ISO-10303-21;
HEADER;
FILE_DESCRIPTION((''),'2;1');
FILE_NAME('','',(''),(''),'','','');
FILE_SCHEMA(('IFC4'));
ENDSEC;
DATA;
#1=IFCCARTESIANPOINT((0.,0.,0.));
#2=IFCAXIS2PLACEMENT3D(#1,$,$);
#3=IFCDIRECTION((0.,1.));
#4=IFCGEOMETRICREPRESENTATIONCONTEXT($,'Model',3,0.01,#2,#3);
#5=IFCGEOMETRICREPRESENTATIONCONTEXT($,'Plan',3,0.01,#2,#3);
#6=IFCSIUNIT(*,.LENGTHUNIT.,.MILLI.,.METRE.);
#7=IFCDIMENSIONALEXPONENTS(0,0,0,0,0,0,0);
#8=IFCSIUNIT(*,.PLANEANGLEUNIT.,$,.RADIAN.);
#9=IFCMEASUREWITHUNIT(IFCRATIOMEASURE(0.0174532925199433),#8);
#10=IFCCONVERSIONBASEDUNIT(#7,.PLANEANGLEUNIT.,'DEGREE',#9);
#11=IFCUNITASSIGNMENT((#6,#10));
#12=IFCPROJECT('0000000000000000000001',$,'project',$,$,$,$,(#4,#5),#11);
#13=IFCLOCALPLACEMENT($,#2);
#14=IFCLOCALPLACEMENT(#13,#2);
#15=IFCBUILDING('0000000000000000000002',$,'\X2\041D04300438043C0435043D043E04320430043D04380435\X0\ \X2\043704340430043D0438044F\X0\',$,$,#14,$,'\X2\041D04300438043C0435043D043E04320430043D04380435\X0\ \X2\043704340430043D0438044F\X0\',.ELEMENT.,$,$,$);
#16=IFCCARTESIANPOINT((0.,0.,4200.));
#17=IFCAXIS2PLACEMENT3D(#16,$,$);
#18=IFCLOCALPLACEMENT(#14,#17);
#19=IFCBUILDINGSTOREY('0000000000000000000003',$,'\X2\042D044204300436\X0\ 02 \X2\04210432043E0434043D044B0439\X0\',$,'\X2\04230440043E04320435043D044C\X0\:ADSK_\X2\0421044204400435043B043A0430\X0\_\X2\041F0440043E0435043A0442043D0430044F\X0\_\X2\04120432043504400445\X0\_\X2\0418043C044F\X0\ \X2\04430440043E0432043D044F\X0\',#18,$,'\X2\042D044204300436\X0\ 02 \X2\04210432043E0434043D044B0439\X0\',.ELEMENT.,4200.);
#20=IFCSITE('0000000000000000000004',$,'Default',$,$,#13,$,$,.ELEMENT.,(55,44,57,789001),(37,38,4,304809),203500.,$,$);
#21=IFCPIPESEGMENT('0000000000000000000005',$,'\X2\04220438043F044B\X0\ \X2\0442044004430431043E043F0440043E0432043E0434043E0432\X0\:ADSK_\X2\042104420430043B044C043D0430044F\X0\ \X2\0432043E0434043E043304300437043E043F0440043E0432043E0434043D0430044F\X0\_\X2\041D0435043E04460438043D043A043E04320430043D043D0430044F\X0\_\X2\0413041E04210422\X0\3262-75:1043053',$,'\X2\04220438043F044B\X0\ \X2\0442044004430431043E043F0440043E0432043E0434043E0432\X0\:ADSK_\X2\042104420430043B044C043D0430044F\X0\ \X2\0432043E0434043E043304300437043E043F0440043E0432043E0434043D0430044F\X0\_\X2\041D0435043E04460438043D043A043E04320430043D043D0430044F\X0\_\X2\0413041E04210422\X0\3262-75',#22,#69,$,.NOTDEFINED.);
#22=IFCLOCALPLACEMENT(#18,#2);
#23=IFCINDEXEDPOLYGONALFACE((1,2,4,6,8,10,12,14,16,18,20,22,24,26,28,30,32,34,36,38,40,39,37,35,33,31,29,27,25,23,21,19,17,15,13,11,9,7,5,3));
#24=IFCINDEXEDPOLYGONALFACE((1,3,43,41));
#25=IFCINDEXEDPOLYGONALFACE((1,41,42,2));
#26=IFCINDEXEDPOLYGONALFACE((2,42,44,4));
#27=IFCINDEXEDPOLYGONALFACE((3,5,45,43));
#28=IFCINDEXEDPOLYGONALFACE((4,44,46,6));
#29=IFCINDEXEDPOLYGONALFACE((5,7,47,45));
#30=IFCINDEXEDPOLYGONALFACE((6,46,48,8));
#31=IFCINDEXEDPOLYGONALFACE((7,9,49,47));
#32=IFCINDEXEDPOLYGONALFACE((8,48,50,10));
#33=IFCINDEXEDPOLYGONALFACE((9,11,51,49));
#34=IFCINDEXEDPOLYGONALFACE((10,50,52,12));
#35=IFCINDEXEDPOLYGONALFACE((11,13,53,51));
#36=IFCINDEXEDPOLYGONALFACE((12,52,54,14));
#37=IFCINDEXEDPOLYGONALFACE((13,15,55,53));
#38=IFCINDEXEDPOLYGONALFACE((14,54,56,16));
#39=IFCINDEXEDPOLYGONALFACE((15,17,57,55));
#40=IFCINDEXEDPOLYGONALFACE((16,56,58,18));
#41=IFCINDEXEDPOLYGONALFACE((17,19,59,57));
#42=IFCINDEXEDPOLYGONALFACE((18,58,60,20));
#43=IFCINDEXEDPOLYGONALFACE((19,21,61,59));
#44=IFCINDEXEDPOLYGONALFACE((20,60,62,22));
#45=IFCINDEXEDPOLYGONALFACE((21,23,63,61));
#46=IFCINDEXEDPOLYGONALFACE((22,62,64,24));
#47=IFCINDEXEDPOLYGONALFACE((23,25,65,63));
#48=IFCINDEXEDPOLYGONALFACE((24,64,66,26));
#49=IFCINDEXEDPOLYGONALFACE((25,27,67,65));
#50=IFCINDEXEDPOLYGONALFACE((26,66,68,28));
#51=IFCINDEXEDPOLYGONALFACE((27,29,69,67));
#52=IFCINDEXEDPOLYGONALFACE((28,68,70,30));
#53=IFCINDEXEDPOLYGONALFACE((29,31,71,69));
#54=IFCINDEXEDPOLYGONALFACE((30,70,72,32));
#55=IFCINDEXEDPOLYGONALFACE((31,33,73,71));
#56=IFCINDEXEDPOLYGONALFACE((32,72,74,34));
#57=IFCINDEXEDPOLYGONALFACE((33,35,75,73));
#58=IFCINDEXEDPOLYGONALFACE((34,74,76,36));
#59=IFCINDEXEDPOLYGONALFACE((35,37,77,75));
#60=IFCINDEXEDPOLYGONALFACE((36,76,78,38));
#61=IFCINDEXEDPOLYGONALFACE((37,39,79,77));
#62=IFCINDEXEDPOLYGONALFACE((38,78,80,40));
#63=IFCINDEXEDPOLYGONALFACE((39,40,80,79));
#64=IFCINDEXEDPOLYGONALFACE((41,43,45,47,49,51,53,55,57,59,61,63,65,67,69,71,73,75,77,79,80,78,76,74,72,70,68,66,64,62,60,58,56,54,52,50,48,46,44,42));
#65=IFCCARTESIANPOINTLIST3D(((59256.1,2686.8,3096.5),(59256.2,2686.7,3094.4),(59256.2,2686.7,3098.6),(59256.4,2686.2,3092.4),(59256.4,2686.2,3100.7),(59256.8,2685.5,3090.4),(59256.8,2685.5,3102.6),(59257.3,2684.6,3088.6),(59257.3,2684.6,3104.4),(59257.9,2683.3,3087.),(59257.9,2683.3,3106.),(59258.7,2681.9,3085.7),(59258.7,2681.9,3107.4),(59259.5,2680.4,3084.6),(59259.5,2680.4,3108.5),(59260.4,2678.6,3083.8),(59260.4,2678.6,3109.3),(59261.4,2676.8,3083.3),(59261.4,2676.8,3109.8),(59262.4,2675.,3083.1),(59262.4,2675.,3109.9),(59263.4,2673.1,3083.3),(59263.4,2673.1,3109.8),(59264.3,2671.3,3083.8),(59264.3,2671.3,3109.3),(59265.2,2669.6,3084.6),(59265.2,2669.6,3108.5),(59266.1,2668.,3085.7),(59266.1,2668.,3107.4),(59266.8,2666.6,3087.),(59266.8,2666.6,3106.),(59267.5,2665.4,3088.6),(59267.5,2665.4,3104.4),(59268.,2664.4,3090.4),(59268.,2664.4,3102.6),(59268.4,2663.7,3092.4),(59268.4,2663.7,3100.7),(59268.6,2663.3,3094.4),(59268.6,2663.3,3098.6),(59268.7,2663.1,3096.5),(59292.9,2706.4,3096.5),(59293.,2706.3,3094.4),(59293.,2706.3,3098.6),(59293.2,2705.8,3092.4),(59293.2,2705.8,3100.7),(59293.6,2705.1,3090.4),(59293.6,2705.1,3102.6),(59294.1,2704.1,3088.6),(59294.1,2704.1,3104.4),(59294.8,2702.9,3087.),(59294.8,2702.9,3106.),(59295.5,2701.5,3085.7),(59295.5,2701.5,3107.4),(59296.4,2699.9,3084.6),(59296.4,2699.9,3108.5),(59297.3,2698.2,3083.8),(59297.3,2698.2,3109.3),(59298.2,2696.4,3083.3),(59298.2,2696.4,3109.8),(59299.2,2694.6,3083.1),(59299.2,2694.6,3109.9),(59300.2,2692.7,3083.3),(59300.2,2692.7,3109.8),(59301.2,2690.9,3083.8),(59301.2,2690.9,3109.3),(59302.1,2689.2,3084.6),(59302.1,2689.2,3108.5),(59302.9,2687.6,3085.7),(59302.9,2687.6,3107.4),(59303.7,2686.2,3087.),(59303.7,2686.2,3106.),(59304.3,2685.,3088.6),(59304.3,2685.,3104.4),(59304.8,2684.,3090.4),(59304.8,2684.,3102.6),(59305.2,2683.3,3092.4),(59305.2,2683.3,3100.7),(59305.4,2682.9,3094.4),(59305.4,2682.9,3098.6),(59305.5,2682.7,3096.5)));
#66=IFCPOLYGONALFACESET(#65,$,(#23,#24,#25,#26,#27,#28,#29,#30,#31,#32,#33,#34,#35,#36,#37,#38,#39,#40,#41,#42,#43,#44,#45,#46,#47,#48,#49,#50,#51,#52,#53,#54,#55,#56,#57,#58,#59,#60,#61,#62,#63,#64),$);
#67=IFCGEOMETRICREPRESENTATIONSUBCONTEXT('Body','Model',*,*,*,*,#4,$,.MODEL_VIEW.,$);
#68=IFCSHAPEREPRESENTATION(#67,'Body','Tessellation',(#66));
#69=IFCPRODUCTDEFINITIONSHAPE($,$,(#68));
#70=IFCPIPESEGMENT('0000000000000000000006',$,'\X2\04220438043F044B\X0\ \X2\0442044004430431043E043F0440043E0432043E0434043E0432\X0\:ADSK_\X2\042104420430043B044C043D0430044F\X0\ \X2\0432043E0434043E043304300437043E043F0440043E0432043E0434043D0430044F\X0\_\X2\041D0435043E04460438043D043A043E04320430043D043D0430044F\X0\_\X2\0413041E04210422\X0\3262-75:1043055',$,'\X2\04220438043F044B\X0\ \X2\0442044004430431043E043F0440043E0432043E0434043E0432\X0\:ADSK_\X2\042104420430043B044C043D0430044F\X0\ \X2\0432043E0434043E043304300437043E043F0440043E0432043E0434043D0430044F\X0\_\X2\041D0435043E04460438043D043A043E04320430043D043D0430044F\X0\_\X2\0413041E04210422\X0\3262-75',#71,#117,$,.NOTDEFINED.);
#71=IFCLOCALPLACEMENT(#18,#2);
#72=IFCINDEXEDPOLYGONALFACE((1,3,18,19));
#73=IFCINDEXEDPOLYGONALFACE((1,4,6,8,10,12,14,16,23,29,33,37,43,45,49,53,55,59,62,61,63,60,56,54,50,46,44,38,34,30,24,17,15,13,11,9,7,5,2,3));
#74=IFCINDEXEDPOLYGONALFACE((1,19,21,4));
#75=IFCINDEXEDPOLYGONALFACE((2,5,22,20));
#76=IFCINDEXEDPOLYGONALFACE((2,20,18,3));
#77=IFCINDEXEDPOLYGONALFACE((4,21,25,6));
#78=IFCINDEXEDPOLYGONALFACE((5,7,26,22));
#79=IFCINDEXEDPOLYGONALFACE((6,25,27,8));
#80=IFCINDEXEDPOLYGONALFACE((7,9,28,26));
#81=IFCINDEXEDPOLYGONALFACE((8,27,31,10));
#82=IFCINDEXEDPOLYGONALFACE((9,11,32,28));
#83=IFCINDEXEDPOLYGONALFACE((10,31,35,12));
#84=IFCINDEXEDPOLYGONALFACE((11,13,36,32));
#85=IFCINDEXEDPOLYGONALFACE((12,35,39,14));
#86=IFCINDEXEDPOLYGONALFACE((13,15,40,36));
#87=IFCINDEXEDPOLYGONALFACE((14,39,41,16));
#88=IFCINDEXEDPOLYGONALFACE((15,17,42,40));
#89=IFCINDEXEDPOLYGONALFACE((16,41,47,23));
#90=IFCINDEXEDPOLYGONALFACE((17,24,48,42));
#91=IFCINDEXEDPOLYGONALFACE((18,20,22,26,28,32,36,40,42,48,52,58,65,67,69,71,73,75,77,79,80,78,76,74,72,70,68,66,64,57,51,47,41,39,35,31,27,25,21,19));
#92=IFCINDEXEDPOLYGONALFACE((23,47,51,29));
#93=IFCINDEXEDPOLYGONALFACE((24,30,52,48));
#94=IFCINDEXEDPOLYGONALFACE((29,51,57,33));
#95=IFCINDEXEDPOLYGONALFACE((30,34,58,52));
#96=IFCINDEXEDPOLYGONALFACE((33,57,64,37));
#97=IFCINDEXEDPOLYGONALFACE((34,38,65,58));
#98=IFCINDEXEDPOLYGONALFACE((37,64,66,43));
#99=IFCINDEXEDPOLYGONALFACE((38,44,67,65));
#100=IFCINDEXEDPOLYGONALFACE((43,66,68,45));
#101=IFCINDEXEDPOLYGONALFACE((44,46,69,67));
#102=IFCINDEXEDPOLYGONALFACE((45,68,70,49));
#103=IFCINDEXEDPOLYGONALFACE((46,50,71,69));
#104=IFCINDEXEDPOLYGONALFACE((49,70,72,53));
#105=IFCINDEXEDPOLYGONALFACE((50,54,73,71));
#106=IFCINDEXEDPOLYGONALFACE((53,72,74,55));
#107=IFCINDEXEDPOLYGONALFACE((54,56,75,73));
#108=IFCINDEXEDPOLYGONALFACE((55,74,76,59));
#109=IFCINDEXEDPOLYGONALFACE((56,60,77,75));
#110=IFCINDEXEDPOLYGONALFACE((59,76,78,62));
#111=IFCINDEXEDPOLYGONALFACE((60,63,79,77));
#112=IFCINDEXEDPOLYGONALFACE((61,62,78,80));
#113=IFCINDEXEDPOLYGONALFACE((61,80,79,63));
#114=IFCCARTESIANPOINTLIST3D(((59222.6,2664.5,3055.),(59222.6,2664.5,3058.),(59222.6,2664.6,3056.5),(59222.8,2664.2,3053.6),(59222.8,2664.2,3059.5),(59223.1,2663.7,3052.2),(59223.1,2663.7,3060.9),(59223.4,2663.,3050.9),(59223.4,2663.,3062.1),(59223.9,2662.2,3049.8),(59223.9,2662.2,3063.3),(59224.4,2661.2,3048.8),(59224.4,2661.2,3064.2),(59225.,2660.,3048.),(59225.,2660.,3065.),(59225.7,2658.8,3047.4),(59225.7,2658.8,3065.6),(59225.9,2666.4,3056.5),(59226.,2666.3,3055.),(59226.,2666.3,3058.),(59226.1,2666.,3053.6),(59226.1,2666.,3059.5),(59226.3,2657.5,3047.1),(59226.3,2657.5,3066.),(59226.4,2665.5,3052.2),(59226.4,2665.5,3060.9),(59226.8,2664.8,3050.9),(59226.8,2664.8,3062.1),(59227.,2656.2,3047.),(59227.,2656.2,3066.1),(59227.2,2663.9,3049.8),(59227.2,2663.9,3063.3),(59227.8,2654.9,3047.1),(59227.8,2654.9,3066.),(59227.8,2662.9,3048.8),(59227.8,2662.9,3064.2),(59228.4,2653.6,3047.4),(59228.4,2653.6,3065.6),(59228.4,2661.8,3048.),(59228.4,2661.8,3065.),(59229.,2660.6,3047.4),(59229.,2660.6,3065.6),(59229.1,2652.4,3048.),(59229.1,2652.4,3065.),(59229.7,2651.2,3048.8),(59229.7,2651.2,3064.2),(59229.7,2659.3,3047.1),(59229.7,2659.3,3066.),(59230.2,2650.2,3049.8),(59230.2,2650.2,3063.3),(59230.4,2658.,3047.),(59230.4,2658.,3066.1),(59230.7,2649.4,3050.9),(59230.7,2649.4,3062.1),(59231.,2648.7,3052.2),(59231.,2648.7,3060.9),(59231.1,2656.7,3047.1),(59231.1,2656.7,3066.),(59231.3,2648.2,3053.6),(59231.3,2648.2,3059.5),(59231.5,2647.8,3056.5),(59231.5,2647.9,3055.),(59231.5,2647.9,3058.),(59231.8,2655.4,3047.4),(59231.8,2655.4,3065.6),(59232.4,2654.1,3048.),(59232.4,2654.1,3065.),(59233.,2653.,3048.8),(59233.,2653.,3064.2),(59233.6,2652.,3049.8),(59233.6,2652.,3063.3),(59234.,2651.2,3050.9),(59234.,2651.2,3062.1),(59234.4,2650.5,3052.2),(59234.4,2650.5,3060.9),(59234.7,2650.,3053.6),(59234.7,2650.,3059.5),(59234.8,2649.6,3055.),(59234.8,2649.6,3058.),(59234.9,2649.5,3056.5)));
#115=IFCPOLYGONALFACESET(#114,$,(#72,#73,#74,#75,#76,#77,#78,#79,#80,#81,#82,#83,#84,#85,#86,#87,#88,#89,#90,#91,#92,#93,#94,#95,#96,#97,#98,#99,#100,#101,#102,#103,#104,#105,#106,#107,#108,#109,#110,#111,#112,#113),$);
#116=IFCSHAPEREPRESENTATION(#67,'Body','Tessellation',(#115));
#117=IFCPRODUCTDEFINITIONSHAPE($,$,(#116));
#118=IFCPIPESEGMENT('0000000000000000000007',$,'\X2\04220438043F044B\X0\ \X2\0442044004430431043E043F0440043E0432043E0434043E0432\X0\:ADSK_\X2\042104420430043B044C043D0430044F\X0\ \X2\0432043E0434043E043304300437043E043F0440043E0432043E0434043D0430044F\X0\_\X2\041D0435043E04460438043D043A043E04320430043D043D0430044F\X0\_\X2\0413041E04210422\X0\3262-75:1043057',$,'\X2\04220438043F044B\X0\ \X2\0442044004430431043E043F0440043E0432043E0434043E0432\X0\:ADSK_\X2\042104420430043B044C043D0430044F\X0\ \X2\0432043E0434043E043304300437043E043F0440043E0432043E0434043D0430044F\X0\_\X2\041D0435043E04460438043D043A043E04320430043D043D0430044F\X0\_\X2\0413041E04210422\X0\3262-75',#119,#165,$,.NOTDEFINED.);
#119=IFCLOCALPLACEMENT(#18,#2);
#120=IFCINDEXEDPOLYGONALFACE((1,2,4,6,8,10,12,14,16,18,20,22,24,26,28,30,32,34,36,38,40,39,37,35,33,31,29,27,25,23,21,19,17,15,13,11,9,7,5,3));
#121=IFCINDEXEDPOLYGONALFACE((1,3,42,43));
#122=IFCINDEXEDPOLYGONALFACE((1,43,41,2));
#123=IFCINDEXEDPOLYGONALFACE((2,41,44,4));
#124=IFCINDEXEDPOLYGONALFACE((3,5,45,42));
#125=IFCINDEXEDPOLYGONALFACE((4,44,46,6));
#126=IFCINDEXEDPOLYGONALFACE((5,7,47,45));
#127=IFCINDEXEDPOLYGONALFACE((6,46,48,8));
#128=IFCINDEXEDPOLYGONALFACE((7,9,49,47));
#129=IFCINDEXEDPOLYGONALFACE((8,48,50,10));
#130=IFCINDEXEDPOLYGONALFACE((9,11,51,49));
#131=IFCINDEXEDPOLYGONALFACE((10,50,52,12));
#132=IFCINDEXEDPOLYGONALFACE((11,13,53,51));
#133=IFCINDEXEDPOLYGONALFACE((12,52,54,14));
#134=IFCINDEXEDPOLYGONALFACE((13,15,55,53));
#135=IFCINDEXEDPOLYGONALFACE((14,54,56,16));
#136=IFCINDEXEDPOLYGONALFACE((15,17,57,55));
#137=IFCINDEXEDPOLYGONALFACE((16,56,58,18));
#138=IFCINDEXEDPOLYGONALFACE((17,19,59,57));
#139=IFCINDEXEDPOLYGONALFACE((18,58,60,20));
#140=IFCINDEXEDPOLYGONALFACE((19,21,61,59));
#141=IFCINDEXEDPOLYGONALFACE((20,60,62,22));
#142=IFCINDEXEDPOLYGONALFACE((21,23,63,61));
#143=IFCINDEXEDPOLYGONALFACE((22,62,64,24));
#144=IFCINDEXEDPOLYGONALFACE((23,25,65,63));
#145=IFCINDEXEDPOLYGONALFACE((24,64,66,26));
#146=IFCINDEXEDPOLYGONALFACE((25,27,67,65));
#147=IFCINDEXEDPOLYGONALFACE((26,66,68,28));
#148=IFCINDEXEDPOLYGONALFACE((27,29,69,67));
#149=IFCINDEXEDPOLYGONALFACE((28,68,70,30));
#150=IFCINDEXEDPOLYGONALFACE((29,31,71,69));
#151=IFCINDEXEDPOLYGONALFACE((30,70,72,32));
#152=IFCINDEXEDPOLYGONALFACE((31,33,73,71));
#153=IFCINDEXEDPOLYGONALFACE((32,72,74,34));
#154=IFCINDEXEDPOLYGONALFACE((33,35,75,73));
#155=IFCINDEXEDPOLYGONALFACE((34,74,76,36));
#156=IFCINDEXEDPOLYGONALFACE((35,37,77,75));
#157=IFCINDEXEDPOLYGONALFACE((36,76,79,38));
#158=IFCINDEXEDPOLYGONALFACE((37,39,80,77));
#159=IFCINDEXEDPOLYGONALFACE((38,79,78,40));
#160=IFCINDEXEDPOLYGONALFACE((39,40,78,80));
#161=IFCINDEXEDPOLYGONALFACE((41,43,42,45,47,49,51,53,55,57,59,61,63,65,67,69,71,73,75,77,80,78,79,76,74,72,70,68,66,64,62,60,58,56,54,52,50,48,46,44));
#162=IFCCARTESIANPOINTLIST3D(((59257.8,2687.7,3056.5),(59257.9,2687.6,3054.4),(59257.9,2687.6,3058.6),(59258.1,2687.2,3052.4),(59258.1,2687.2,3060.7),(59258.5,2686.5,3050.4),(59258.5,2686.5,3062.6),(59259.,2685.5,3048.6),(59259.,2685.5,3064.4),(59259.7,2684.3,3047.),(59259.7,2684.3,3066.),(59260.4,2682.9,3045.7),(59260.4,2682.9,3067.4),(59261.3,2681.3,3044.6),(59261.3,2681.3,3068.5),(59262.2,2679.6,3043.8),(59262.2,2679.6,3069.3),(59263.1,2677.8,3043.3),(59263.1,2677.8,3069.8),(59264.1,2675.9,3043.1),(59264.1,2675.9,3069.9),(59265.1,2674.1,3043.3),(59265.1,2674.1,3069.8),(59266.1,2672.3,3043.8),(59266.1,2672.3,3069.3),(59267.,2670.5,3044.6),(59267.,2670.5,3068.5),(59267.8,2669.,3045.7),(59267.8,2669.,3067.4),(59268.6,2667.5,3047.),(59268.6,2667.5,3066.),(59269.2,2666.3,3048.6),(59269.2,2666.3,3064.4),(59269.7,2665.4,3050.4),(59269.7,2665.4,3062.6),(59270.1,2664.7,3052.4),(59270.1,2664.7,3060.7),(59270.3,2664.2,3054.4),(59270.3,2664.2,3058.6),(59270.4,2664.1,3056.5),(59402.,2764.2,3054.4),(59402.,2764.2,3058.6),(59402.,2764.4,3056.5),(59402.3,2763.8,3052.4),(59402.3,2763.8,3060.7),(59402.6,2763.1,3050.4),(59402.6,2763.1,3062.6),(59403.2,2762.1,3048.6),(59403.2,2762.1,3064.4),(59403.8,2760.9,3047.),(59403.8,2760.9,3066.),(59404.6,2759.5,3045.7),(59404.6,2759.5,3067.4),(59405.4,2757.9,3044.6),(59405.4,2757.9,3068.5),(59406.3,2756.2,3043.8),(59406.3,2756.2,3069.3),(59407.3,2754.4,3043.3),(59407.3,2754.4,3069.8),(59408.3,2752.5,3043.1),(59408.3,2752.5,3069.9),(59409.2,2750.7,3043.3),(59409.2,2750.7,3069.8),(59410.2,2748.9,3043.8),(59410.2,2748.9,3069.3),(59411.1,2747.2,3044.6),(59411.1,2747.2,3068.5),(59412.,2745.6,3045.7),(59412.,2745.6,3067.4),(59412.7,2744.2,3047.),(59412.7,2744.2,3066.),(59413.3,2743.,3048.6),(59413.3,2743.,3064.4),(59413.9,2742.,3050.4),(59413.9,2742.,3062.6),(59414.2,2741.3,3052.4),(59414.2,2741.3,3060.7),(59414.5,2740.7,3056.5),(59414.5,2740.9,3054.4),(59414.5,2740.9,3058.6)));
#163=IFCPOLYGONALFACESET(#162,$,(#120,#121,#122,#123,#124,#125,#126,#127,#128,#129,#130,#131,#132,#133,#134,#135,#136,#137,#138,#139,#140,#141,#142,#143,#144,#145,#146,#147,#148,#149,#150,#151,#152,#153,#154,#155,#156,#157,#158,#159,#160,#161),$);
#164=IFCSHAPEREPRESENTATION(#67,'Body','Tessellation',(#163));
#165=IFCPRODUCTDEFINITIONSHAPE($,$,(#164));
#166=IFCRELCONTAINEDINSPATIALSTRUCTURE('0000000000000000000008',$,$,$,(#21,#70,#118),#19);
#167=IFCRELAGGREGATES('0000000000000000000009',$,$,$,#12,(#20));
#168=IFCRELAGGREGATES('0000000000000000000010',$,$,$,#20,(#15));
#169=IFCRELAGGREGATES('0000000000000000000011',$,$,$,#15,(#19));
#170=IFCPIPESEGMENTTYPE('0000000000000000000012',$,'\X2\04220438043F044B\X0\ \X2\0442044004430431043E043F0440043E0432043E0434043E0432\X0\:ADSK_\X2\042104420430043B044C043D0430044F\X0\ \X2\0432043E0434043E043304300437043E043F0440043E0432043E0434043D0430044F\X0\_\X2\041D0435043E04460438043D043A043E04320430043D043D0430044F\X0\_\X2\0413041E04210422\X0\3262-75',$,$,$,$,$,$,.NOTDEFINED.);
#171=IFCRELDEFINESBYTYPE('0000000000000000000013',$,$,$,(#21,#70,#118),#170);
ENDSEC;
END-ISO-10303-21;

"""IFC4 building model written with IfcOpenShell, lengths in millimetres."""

from ifc_helpers import new_model, entity, si_unit, converted_unit, direction, frame, origin, place, context, subcontext, project, spatial, indexed_curve, outline, extrude, type_object, element, save


model = new_model("IFC4")

# Units and contexts
model_context = context("Model", 3, precision=0.01, world=origin(), true_north=direction((0.0, 1.0)))
plan_context = context("Plan", 3, precision=0.01, world=origin(), true_north=direction((0.0, 1.0)))
body_context = subcontext(model_context, "Body", "Model", "MODEL_VIEW")
ifc_project = project(units=[si_unit("LENGTHUNIT", "METRE", prefix="MILLI"), converted_unit("PLANEANGLEUNIT", "DEGREE", entity("IfcRatioMeasure", 0.0174532925199433), si_unit("PLANEANGLEUNIT", "RADIAN"), dimensions=[0, 0, 0, 0, 0, 0, 0])], contexts=[model_context, plan_context])

# Site, building, storey
site_placement = place(None, origin())
site = spatial("IfcSite", under=ifc_project, at=site_placement, Name="Default", CompositionType="ELEMENT", RefLatitude=(55, 44, 57, 789001), RefLongitude=(37, 38, 4, 304809), RefElevation=203500.0)
building_placement = place(site_placement, origin())
building = spatial("IfcBuilding", under=site, at=building_placement, Name="Наименование здания", LongName="Наименование здания", CompositionType="ELEMENT")
storey_placement = place(building_placement, frame((0.0, 0.0, 4200.0)))
storey = spatial("IfcBuildingStorey", under=building, at=storey_placement, Name="Этаж 02 Сводный", ObjectType="Уровень:ADSK_Стрелка_Проектная_Вверх_Имя уровня", LongName="Этаж 02 Сводный", CompositionType="ELEMENT", Elevation=4200.0)

# Pipe segments
pipe_segment_type = type_object("IfcPipeSegmentType", Name="Типы трубопроводов:ADSK_Стальная водогазопроводная_Неоцинкованная_ГОСТ3262-75", PredefinedType="NOTDEFINED")
placement = place(storey_placement, origin())
element("IfcPipeSegment", 1, at=placement, inside=storey, type_object=pipe_segment_type, Name="Типы трубопроводов:ADSK_Стальная водогазопроводная_Неоцинкованная_ГОСТ3262-75:1043053", ObjectType="Типы трубопроводов:ADSK_Стальная водогазопроводная_Неоцинкованная_ГОСТ3262-75", PredefinedType="NOTDEFINED", context=body_context, shape_type="SweptSolid", body=[
    extrude(outline(indexed_curve([(13.4, 0.0), (13.2, 2.1), (12.7, 4.1), (11.9, 6.1), (10.8, 7.9), (9.5, 9.5), (7.9, 10.8), (6.1, 11.9), (4.1, 12.7), (2.1, 13.2), (0.0, 13.4), (-2.1, 13.2), (-4.1, 12.7), (-6.1, 11.9), (-7.9, 10.8), (-9.5, 9.5), (-10.8, 7.9), (-11.9, 6.1), (-12.7, 4.1), (-13.2, 2.1), (-13.4, 0.0), (-13.2, -2.1), (-12.7, -4.1), (-11.9, -6.1), (-10.8, -7.9), (-9.5, -9.5), (-7.9, -10.8), (-6.1, -11.9), (-4.1, -12.7), (-2.1, -13.2), (0.0, -13.4), (2.1, -13.2), (4.1, -12.7), (6.1, -11.9), (7.9, -10.8), (9.5, -9.5), (10.8, -7.9), (11.9, -6.1), (12.7, -4.1), (13.2, -2.1), (13.4, 0.0)], self_intersect=False)), frame((59262.4, 2675.0, 3096.5), z_axis=(0.882948, 0.469472, 0.0), x_axis=(0.469472, -0.882948, 0.0)), (0.0, 0.0, 1.0), 41.7),
])
element("IfcPipeSegment", 2, at=placement, inside=storey, type_object=pipe_segment_type, Name="Типы трубопроводов:ADSK_Стальная водогазопроводная_Неоцинкованная_ГОСТ3262-75:1043055", ObjectType="Типы трубопроводов:ADSK_Стальная водогазопроводная_Неоцинкованная_ГОСТ3262-75", PredefinedType="NOTDEFINED", context=body_context, shape_type="SweptSolid", body=[
    extrude(outline(indexed_curve([(9.5, 0.0), (9.4, 1.5), (9.1, 3.0), (8.5, 4.3), (7.7, 5.6), (6.8, 6.8), (5.6, 7.7), (4.3, 8.5), (3.0, 9.1), (1.5, 9.4), (0.0, 9.6), (-1.5, 9.4), (-3.0, 9.1), (-4.3, 8.5), (-5.6, 7.7), (-6.8, 6.8), (-7.7, 5.6), (-8.5, 4.3), (-9.1, 3.0), (-9.4, 1.5), (-9.5, 0.0), (-9.4, -1.5), (-9.1, -3.0), (-8.5, -4.3), (-7.7, -5.6), (-6.8, -6.8), (-5.6, -7.7), (-4.3, -8.5), (-3.0, -9.1), (-1.5, -9.4), (0.0, -9.6), (1.5, -9.4), (3.0, -9.1), (4.3, -8.5), (5.6, -7.7), (6.8, -6.8), (7.7, -5.6), (8.5, -4.3), (9.1, -3.0), (9.4, -1.5), (9.5, 0.0)], self_intersect=False)), frame((59227.1, 2656.2, 3056.5), z_axis=(0.882948, 0.469472, 0.0), x_axis=(0.469472, -0.882948, 0.0)), (0.0, 0.0, 1.0), 3.8),
])
element("IfcPipeSegment", 3, at=placement, inside=storey, type_object=pipe_segment_type, Name="Типы трубопроводов:ADSK_Стальная водогазопроводная_Неоцинкованная_ГОСТ3262-75:1043057", ObjectType="Типы трубопроводов:ADSK_Стальная водогазопроводная_Неоцинкованная_ГОСТ3262-75", PredefinedType="NOTDEFINED", context=body_context, shape_type="SweptSolid", body=[
    extrude(outline(indexed_curve([(13.4, 0.0), (13.2, 2.1), (12.7, 4.1), (11.9, 6.1), (10.8, 7.9), (9.5, 9.5), (7.9, 10.8), (6.1, 11.9), (4.1, 12.7), (2.1, 13.2), (0.0, 13.4), (-2.1, 13.2), (-4.1, 12.7), (-6.1, 11.9), (-7.9, 10.8), (-9.5, 9.5), (-10.8, 7.9), (-11.9, 6.1), (-12.7, 4.1), (-13.2, 2.1), (-13.4, 0.0), (-13.2, -2.1), (-12.7, -4.1), (-11.9, -6.1), (-10.8, -7.9), (-9.5, -9.5), (-7.9, -10.8), (-6.1, -11.9), (-4.1, -12.7), (-2.1, -13.2), (0.0, -13.4), (2.1, -13.2), (4.1, -12.7), (6.1, -11.9), (7.9, -10.8), (9.5, -9.5), (10.8, -7.9), (11.9, -6.1), (12.7, -4.1), (13.2, -2.1), (13.4, 0.0)], self_intersect=False)), frame((59264.1, 2675.9, 3056.5), z_axis=(0.882948, 0.469472, 0.0), x_axis=(0.469472, -0.882948, 0.0)), (0.0, 0.0, 1.0), 163.2),
])

save(model, "model.ifc")
